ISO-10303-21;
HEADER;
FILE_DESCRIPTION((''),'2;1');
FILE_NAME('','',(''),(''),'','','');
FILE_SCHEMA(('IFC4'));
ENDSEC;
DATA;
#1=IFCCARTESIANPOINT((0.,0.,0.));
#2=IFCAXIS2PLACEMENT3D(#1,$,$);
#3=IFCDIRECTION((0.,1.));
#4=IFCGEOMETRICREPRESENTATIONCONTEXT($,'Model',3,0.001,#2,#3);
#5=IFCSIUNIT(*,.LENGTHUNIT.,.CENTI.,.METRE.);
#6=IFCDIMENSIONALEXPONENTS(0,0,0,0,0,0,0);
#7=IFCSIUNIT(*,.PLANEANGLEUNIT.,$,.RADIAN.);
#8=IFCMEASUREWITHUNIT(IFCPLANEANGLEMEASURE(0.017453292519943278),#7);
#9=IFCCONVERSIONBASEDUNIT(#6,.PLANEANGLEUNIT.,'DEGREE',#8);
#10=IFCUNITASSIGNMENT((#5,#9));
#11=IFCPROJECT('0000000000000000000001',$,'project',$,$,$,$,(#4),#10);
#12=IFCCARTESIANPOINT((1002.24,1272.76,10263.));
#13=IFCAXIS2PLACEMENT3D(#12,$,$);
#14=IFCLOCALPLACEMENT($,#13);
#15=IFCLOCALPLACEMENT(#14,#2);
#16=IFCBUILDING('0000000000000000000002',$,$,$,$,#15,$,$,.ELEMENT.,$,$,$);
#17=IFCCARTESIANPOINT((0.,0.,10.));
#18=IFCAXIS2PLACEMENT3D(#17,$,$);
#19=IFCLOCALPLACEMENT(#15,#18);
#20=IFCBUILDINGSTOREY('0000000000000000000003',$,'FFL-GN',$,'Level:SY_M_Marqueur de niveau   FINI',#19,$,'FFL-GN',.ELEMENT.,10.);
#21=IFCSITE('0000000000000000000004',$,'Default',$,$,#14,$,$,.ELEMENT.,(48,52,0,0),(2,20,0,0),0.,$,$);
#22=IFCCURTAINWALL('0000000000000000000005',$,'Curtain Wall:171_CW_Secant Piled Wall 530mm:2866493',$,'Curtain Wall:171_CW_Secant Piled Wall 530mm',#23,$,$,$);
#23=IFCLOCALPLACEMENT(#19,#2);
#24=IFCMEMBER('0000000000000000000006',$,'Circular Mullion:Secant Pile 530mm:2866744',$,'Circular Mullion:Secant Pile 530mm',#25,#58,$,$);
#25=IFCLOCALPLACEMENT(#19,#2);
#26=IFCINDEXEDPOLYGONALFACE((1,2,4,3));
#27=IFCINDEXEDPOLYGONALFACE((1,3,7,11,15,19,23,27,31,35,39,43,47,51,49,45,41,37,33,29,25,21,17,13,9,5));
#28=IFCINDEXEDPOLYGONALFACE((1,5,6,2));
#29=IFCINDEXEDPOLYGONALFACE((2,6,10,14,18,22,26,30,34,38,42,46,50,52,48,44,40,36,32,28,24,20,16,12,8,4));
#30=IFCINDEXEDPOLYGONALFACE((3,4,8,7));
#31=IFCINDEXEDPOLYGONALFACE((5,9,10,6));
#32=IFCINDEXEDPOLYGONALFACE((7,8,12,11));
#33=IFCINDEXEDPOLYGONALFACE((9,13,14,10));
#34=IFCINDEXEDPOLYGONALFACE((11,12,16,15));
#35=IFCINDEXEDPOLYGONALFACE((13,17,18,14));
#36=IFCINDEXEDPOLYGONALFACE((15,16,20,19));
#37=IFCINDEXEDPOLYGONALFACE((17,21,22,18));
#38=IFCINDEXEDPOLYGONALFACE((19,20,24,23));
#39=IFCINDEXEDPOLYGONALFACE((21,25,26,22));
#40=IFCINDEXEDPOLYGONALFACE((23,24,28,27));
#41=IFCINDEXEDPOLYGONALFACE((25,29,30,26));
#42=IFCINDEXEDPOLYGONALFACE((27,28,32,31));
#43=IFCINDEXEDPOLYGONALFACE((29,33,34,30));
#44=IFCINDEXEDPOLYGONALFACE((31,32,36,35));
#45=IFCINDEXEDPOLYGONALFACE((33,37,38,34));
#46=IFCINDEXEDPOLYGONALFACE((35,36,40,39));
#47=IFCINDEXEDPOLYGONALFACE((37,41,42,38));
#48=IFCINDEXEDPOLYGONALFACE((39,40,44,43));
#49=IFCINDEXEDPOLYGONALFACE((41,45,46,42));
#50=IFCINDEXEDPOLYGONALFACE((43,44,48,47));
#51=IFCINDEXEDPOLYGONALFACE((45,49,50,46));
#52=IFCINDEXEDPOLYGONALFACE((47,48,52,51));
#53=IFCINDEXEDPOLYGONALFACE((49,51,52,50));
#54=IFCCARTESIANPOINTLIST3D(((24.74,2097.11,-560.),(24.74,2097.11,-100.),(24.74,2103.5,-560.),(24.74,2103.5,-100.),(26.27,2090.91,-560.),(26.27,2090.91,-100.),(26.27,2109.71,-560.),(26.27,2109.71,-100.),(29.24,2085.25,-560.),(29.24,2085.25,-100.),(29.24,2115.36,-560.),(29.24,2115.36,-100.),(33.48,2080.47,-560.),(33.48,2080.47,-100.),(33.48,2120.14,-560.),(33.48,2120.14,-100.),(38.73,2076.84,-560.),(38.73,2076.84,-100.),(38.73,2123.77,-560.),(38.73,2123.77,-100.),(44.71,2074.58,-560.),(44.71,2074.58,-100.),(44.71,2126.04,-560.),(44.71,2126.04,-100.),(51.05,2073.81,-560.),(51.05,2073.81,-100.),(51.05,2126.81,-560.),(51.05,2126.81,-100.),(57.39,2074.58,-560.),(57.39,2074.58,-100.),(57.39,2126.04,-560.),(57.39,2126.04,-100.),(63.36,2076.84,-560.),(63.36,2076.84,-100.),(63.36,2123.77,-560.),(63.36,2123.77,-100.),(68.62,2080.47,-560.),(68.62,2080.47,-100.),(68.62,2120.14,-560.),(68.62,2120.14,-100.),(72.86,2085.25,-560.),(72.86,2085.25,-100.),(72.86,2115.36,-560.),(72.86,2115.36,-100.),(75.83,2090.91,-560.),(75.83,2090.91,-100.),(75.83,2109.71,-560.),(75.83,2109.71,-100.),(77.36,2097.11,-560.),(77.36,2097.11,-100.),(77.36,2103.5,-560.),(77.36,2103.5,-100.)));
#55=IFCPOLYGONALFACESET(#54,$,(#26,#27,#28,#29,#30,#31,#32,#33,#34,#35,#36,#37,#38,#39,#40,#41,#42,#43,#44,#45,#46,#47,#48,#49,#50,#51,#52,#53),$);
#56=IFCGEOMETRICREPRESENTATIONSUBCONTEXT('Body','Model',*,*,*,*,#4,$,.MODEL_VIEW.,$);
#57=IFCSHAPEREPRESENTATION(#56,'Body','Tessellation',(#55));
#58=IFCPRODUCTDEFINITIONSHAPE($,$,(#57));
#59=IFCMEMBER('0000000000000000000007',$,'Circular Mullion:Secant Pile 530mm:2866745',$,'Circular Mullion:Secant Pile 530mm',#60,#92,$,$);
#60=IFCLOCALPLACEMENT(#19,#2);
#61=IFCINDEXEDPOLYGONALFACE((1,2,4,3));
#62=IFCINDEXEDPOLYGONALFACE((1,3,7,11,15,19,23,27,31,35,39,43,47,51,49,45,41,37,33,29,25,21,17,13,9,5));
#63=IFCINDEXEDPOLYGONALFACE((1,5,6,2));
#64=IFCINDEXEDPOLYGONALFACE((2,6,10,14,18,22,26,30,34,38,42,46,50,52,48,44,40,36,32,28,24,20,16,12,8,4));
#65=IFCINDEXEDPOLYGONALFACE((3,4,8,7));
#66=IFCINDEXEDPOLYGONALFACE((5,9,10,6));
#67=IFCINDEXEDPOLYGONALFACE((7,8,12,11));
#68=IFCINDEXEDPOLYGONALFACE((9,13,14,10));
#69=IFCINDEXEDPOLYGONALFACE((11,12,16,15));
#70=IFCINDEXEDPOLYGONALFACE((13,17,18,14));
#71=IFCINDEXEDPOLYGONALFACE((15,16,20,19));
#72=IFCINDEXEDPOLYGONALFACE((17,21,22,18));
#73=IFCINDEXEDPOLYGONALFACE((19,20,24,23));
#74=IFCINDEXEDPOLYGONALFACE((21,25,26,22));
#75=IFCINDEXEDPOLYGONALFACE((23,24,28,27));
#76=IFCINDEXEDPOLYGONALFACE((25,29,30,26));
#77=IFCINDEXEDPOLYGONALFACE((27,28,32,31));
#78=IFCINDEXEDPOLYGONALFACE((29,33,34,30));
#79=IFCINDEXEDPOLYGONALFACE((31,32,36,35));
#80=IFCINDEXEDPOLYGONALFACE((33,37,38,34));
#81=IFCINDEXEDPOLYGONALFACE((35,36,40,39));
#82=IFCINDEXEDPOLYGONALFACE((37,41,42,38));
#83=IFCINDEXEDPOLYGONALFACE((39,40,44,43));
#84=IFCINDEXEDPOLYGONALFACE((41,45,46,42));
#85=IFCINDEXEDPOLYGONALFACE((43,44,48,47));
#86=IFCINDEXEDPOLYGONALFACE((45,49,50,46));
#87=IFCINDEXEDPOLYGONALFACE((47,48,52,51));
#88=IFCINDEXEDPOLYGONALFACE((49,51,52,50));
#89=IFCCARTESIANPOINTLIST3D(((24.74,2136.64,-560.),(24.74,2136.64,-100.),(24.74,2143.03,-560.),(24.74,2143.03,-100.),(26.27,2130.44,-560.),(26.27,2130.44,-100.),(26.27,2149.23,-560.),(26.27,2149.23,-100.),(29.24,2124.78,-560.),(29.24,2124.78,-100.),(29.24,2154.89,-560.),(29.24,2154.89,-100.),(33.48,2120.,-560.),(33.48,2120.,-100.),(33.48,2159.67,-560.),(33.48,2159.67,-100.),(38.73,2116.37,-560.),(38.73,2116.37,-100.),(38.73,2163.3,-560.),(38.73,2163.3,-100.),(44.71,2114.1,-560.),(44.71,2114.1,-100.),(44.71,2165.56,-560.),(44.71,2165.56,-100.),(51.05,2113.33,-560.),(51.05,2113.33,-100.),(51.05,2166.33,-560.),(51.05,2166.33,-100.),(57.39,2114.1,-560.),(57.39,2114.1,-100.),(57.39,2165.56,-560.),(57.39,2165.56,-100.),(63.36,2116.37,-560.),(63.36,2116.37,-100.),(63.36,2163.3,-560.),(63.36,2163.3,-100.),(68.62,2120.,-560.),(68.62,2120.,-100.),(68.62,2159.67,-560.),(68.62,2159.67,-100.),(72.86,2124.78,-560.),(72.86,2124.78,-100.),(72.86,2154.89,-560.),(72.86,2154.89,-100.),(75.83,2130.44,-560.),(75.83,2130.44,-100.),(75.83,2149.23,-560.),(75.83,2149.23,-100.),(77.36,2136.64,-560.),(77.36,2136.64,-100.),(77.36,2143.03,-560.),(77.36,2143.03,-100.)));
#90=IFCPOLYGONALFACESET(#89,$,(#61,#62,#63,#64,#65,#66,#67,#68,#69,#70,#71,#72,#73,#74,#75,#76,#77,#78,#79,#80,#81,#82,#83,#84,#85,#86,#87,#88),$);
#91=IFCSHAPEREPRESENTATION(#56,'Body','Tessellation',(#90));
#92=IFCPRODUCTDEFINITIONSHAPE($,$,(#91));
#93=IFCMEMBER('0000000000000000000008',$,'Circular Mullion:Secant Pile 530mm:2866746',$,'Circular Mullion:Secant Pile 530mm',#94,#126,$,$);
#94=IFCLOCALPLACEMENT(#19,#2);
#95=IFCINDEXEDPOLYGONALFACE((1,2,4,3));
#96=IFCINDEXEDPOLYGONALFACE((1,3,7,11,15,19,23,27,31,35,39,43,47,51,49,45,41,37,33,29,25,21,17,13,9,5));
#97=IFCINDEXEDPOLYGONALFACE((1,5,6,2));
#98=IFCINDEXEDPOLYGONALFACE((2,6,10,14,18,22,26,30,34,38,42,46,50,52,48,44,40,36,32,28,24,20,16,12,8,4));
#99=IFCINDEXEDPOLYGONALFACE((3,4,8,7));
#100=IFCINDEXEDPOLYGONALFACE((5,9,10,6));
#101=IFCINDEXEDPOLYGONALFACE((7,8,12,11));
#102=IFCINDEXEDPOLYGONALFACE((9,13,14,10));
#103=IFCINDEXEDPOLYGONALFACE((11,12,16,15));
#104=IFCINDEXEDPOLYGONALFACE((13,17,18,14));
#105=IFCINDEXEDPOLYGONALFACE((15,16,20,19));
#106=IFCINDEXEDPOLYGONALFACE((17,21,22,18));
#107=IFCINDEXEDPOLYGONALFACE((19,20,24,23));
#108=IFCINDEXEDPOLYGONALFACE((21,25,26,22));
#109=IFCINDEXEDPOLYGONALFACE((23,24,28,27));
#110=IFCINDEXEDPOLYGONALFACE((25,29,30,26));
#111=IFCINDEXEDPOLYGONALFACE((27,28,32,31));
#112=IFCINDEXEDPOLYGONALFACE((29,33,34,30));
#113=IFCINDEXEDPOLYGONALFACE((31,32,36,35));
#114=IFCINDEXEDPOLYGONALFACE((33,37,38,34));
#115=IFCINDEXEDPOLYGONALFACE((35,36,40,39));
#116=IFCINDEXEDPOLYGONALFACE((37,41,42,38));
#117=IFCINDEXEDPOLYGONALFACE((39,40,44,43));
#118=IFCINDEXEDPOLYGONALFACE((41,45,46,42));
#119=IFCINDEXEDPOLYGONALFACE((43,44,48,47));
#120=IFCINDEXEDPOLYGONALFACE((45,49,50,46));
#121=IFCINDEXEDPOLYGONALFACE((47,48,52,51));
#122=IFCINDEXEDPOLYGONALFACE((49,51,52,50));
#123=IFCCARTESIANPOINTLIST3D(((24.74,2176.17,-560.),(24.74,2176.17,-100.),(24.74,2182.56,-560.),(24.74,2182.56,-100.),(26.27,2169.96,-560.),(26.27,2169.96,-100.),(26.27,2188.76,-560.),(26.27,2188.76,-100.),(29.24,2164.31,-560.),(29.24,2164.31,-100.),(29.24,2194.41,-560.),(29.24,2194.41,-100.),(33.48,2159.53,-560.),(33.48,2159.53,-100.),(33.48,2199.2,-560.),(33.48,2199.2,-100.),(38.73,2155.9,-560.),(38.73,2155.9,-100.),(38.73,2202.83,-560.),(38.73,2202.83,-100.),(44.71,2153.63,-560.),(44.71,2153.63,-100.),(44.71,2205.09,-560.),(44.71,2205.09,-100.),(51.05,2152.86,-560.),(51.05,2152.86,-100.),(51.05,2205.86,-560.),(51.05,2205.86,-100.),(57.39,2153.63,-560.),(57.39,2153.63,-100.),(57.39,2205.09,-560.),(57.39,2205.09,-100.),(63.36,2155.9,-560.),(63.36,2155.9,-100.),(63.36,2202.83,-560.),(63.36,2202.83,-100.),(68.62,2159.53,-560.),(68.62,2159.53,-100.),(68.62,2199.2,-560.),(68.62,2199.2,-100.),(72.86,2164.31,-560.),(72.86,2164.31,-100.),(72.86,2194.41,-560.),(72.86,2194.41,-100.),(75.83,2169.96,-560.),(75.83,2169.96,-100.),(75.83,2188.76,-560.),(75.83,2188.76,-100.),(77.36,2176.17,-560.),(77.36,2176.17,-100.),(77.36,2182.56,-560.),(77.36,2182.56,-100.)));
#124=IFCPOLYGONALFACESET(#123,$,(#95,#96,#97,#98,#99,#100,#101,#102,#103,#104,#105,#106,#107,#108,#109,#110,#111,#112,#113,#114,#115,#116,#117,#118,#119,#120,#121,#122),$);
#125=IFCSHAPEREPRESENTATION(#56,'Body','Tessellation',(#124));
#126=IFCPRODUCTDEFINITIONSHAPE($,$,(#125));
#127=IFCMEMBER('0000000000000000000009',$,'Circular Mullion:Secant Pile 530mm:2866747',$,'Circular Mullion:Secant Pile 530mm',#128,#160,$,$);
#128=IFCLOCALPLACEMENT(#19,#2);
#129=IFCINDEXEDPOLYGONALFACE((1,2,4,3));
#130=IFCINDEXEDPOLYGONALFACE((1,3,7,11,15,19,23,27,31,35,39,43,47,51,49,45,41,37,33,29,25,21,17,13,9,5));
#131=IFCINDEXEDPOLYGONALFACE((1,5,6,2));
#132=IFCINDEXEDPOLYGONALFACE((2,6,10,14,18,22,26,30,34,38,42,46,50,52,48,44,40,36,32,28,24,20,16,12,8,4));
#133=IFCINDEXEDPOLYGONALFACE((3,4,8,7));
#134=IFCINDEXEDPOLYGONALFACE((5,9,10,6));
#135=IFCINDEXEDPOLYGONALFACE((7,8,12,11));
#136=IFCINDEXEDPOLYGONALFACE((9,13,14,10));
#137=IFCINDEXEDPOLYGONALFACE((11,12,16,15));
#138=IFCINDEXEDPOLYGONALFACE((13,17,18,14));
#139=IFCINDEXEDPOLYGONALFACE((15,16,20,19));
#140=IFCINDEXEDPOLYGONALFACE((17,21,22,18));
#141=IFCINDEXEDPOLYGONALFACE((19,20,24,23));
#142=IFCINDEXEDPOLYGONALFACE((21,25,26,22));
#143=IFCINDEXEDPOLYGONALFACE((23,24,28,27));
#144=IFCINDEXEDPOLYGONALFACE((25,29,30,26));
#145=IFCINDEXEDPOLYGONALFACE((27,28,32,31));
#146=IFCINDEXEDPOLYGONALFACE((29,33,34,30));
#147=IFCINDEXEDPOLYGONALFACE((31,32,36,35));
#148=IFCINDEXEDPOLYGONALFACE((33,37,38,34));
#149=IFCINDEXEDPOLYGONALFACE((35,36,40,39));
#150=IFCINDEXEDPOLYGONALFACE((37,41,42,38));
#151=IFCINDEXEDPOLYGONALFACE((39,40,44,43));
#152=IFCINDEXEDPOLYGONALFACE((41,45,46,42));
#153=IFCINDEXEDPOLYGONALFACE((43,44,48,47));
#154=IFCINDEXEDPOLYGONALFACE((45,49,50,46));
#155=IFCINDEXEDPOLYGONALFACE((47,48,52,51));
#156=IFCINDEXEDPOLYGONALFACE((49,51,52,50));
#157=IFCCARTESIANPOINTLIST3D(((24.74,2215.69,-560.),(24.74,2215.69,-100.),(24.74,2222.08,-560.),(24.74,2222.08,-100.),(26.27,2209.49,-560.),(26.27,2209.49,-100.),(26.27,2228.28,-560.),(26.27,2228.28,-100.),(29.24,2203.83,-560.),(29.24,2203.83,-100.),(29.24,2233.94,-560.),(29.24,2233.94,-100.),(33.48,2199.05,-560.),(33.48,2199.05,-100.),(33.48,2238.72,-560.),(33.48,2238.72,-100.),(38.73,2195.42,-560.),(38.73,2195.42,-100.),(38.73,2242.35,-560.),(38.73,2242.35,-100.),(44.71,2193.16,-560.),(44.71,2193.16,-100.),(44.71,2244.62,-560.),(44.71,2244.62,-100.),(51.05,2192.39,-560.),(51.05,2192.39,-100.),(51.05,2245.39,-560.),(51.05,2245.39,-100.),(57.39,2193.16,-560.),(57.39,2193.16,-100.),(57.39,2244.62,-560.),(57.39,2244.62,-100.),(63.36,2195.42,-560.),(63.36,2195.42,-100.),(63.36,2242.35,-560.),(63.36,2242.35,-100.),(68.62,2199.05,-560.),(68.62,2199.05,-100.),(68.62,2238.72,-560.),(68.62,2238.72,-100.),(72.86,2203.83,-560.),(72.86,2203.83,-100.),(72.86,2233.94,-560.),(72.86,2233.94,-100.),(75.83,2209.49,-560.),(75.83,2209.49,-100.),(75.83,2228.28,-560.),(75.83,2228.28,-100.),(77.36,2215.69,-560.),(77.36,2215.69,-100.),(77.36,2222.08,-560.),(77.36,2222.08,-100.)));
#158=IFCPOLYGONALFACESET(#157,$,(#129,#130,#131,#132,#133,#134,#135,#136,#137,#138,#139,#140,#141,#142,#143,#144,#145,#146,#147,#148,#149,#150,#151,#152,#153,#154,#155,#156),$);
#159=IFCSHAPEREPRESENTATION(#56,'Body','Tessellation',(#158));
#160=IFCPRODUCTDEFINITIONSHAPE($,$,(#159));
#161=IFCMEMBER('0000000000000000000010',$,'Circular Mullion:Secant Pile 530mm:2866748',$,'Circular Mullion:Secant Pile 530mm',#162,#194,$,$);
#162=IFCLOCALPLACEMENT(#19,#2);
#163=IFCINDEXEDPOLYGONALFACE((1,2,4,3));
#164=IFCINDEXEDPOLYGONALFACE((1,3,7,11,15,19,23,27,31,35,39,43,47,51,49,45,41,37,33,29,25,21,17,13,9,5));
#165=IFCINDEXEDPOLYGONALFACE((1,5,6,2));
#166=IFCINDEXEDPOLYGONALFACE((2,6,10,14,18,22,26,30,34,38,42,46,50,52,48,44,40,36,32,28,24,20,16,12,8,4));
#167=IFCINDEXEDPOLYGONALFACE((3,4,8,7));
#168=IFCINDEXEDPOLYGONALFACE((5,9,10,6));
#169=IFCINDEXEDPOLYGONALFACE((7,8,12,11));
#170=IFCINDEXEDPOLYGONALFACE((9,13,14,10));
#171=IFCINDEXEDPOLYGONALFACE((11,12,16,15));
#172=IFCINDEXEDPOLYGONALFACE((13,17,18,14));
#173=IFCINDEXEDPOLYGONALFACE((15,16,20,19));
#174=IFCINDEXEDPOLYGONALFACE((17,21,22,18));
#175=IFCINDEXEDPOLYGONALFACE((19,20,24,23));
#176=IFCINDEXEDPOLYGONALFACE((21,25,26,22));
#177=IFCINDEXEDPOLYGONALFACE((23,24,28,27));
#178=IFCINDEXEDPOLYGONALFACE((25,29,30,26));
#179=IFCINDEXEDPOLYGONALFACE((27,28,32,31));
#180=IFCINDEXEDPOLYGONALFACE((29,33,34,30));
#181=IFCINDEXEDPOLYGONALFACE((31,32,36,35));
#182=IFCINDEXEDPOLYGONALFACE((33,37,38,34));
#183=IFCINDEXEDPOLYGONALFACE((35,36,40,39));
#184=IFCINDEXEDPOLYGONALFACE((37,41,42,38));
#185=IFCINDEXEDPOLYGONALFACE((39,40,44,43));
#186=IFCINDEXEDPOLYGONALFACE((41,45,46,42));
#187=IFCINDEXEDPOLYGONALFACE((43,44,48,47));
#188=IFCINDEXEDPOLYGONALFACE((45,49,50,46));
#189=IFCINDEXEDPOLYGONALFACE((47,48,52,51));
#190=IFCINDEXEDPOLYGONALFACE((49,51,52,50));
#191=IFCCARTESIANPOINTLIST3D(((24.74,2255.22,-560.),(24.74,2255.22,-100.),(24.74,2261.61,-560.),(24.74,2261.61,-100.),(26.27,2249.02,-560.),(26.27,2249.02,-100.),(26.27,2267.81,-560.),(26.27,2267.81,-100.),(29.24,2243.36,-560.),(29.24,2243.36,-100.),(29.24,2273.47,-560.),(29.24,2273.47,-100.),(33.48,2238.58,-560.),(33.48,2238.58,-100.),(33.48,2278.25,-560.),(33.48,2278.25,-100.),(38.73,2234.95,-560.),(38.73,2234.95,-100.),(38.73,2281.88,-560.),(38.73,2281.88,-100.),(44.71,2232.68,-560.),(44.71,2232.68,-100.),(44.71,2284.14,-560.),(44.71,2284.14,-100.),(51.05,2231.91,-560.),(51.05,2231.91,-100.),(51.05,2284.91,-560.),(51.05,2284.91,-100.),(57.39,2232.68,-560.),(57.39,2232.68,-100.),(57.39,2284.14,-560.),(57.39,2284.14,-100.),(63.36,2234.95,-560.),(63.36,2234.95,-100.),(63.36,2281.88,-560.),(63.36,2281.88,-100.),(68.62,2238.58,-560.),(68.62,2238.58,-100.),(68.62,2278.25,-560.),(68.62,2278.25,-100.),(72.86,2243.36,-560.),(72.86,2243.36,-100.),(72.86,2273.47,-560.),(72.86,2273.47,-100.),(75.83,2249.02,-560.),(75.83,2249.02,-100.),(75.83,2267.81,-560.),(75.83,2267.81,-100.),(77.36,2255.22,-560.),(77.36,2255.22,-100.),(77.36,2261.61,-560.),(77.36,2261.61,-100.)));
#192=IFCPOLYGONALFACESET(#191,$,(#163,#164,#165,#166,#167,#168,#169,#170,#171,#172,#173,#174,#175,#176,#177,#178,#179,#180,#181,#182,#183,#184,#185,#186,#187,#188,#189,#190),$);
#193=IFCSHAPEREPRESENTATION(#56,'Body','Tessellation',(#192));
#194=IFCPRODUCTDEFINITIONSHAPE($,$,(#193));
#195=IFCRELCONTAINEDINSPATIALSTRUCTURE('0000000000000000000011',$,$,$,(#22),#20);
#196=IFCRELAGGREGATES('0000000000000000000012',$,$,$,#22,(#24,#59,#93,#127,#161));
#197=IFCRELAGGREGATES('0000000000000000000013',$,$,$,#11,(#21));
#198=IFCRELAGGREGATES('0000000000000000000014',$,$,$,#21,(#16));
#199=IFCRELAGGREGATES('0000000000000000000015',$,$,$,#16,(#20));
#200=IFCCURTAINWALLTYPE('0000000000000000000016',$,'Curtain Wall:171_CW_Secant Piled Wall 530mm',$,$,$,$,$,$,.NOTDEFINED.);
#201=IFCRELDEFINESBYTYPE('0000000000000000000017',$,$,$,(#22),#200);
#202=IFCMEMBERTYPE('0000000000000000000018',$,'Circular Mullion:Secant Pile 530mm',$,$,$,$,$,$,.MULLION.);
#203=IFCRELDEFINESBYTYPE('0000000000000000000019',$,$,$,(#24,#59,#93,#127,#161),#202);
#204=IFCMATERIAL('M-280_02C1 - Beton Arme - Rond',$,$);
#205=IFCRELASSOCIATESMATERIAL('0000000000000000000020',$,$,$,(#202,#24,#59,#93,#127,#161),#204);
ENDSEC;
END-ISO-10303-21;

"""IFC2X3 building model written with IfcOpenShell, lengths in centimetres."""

from ifc_helpers import new_model, entity, si_unit, converted_unit, direction, frame, frame_2d, origin, place, context, subcontext, project, spatial, circle, extrude, source, transform, mapped, material, type_object, type_shapes, element, aggregate, save


model = new_model("IFC2X3")

# Units and contexts
model_context = context("Model", 3, precision=0.001, world=origin(), true_north=direction((0.0, 1.0)))
body_context = subcontext(model_context, "Body", "Model", "MODEL_VIEW")
ifc_project = project(units=[si_unit("LENGTHUNIT", "METRE", prefix="CENTI"), converted_unit("PLANEANGLEUNIT", "DEGREE", entity("IfcPlaneAngleMeasure", 0.017453292519943278), si_unit("PLANEANGLEUNIT", "RADIAN"), dimensions=[0, 0, 0, 0, 0, 0, 0])], contexts=[model_context])

# Site, building, storey
site_placement = place(None, frame((1002.24, 1272.76, 10263.0)))
site = spatial("IfcSite", under=ifc_project, at=site_placement, Name="Default", CompositionType="ELEMENT", RefLatitude=(48, 52, 0, 0), RefLongitude=(2, 20, 0, 0), RefElevation=0.0)
building_placement = place(site_placement, origin())
building = spatial("IfcBuilding", under=site, at=building_placement, CompositionType="ELEMENT")
storey_placement = place(building_placement, frame((0.0, 0.0, 10.0)))
storey = spatial("IfcBuildingStorey", under=building, at=storey_placement, Name="FFL-GN", ObjectType="Level:SY_M_Marqueur de niveau   FINI", LongName="FFL-GN", CompositionType="ELEMENT", Elevation=10.0)

# Curtain wall, members
curtain_wall_type = type_object("IfcCurtainWallType", Name="Curtain Wall:171_CW_Secant Piled Wall 530mm", PredefinedType="NOTDEFINED")
curtain_wall_placement = place(storey_placement, frame((0.0, 0.0, -10.0)))
curtain_wall = element("IfcCurtainWall", 1, at=curtain_wall_placement, inside=storey, type_object=curtain_wall_type, Name="Curtain Wall:171_CW_Secant Piled Wall 530mm:2866493", ObjectType="Curtain Wall:171_CW_Secant Piled Wall 530mm")
ifc_material_1 = material(Name="M-280_02C1 - Beton Arme - Rond")
member_type = type_object("IfcMemberType", Name="Circular Mullion:Secant Pile 530mm", PredefinedType="MULLION", material=ifc_material_1)
shared_shape = source(origin(), body_context, "Body", "SweptSolid", [
    extrude(circle(Radius=26.5, at=frame_2d((0.0, 0.0), x_axis=(1.0, 0.0))), frame((0.0, 0.0, -460.0)), (0.0, 0.0, 1.0), 460.0),
])
type_shapes(member_type, [shared_shape])
member_1_placement = place(curtain_wall_placement, frame((51.05, 2100.31, -550.0), z_axis=(0.0, 0.0, -1.0), x_axis=(0.0, 1.0, 0.0)))
member_1 = element("IfcMember", 2, at=member_1_placement, type_object=member_type, material=ifc_material_1, Name="Circular Mullion:Secant Pile 530mm:2866744", ObjectType="Circular Mullion:Secant Pile 530mm", context=body_context, shape_type="MappedRepresentation", body=[
    mapped(shared_shape, transform((0.0, 0.0, 0.0), scale=1.0)),
])
member_2_placement = place(curtain_wall_placement, frame((51.05, 2139.83, -550.0), z_axis=(0.0, 0.0, -1.0), x_axis=(0.0, 1.0, 0.0)))
member_2 = element("IfcMember", 3, at=member_2_placement, type_object=member_type, material=ifc_material_1, Name="Circular Mullion:Secant Pile 530mm:2866745", ObjectType="Circular Mullion:Secant Pile 530mm", context=body_context, shape_type="MappedRepresentation", body=[
    mapped(shared_shape, transform((0.0, 0.0, 0.0), scale=1.0)),
])
member_3_placement = place(curtain_wall_placement, frame((51.05, 2179.36, -550.0), z_axis=(0.0, 0.0, -1.0), x_axis=(0.0, 1.0, 0.0)))
member_3 = element("IfcMember", 4, at=member_3_placement, type_object=member_type, material=ifc_material_1, Name="Circular Mullion:Secant Pile 530mm:2866746", ObjectType="Circular Mullion:Secant Pile 530mm", context=body_context, shape_type="MappedRepresentation", body=[
    mapped(shared_shape, transform((0.0, 0.0, 0.0), scale=1.0)),
])
member_4_placement = place(curtain_wall_placement, frame((51.05, 2218.89, -550.0), z_axis=(0.0, 0.0, -1.0), x_axis=(0.0, 1.0, 0.0)))
member_4 = element("IfcMember", 5, at=member_4_placement, type_object=member_type, material=ifc_material_1, Name="Circular Mullion:Secant Pile 530mm:2866747", ObjectType="Circular Mullion:Secant Pile 530mm", context=body_context, shape_type="MappedRepresentation", body=[
    mapped(shared_shape, transform((0.0, 0.0, 0.0), scale=1.0)),
])
member_5_placement = place(curtain_wall_placement, frame((51.05, 2258.41, -550.0), z_axis=(0.0, 0.0, -1.0), x_axis=(0.0, 1.0, 0.0)))
member_5 = element("IfcMember", 6, at=member_5_placement, type_object=member_type, material=ifc_material_1, Name="Circular Mullion:Secant Pile 530mm:2866748", ObjectType="Circular Mullion:Secant Pile 530mm", context=body_context, shape_type="MappedRepresentation", body=[
    mapped(shared_shape, transform((0.0, 0.0, 0.0), scale=1.0)),
])
aggregate(curtain_wall, [member_1, member_2, member_3, member_4, member_5])

save(model, "model.ifc")
